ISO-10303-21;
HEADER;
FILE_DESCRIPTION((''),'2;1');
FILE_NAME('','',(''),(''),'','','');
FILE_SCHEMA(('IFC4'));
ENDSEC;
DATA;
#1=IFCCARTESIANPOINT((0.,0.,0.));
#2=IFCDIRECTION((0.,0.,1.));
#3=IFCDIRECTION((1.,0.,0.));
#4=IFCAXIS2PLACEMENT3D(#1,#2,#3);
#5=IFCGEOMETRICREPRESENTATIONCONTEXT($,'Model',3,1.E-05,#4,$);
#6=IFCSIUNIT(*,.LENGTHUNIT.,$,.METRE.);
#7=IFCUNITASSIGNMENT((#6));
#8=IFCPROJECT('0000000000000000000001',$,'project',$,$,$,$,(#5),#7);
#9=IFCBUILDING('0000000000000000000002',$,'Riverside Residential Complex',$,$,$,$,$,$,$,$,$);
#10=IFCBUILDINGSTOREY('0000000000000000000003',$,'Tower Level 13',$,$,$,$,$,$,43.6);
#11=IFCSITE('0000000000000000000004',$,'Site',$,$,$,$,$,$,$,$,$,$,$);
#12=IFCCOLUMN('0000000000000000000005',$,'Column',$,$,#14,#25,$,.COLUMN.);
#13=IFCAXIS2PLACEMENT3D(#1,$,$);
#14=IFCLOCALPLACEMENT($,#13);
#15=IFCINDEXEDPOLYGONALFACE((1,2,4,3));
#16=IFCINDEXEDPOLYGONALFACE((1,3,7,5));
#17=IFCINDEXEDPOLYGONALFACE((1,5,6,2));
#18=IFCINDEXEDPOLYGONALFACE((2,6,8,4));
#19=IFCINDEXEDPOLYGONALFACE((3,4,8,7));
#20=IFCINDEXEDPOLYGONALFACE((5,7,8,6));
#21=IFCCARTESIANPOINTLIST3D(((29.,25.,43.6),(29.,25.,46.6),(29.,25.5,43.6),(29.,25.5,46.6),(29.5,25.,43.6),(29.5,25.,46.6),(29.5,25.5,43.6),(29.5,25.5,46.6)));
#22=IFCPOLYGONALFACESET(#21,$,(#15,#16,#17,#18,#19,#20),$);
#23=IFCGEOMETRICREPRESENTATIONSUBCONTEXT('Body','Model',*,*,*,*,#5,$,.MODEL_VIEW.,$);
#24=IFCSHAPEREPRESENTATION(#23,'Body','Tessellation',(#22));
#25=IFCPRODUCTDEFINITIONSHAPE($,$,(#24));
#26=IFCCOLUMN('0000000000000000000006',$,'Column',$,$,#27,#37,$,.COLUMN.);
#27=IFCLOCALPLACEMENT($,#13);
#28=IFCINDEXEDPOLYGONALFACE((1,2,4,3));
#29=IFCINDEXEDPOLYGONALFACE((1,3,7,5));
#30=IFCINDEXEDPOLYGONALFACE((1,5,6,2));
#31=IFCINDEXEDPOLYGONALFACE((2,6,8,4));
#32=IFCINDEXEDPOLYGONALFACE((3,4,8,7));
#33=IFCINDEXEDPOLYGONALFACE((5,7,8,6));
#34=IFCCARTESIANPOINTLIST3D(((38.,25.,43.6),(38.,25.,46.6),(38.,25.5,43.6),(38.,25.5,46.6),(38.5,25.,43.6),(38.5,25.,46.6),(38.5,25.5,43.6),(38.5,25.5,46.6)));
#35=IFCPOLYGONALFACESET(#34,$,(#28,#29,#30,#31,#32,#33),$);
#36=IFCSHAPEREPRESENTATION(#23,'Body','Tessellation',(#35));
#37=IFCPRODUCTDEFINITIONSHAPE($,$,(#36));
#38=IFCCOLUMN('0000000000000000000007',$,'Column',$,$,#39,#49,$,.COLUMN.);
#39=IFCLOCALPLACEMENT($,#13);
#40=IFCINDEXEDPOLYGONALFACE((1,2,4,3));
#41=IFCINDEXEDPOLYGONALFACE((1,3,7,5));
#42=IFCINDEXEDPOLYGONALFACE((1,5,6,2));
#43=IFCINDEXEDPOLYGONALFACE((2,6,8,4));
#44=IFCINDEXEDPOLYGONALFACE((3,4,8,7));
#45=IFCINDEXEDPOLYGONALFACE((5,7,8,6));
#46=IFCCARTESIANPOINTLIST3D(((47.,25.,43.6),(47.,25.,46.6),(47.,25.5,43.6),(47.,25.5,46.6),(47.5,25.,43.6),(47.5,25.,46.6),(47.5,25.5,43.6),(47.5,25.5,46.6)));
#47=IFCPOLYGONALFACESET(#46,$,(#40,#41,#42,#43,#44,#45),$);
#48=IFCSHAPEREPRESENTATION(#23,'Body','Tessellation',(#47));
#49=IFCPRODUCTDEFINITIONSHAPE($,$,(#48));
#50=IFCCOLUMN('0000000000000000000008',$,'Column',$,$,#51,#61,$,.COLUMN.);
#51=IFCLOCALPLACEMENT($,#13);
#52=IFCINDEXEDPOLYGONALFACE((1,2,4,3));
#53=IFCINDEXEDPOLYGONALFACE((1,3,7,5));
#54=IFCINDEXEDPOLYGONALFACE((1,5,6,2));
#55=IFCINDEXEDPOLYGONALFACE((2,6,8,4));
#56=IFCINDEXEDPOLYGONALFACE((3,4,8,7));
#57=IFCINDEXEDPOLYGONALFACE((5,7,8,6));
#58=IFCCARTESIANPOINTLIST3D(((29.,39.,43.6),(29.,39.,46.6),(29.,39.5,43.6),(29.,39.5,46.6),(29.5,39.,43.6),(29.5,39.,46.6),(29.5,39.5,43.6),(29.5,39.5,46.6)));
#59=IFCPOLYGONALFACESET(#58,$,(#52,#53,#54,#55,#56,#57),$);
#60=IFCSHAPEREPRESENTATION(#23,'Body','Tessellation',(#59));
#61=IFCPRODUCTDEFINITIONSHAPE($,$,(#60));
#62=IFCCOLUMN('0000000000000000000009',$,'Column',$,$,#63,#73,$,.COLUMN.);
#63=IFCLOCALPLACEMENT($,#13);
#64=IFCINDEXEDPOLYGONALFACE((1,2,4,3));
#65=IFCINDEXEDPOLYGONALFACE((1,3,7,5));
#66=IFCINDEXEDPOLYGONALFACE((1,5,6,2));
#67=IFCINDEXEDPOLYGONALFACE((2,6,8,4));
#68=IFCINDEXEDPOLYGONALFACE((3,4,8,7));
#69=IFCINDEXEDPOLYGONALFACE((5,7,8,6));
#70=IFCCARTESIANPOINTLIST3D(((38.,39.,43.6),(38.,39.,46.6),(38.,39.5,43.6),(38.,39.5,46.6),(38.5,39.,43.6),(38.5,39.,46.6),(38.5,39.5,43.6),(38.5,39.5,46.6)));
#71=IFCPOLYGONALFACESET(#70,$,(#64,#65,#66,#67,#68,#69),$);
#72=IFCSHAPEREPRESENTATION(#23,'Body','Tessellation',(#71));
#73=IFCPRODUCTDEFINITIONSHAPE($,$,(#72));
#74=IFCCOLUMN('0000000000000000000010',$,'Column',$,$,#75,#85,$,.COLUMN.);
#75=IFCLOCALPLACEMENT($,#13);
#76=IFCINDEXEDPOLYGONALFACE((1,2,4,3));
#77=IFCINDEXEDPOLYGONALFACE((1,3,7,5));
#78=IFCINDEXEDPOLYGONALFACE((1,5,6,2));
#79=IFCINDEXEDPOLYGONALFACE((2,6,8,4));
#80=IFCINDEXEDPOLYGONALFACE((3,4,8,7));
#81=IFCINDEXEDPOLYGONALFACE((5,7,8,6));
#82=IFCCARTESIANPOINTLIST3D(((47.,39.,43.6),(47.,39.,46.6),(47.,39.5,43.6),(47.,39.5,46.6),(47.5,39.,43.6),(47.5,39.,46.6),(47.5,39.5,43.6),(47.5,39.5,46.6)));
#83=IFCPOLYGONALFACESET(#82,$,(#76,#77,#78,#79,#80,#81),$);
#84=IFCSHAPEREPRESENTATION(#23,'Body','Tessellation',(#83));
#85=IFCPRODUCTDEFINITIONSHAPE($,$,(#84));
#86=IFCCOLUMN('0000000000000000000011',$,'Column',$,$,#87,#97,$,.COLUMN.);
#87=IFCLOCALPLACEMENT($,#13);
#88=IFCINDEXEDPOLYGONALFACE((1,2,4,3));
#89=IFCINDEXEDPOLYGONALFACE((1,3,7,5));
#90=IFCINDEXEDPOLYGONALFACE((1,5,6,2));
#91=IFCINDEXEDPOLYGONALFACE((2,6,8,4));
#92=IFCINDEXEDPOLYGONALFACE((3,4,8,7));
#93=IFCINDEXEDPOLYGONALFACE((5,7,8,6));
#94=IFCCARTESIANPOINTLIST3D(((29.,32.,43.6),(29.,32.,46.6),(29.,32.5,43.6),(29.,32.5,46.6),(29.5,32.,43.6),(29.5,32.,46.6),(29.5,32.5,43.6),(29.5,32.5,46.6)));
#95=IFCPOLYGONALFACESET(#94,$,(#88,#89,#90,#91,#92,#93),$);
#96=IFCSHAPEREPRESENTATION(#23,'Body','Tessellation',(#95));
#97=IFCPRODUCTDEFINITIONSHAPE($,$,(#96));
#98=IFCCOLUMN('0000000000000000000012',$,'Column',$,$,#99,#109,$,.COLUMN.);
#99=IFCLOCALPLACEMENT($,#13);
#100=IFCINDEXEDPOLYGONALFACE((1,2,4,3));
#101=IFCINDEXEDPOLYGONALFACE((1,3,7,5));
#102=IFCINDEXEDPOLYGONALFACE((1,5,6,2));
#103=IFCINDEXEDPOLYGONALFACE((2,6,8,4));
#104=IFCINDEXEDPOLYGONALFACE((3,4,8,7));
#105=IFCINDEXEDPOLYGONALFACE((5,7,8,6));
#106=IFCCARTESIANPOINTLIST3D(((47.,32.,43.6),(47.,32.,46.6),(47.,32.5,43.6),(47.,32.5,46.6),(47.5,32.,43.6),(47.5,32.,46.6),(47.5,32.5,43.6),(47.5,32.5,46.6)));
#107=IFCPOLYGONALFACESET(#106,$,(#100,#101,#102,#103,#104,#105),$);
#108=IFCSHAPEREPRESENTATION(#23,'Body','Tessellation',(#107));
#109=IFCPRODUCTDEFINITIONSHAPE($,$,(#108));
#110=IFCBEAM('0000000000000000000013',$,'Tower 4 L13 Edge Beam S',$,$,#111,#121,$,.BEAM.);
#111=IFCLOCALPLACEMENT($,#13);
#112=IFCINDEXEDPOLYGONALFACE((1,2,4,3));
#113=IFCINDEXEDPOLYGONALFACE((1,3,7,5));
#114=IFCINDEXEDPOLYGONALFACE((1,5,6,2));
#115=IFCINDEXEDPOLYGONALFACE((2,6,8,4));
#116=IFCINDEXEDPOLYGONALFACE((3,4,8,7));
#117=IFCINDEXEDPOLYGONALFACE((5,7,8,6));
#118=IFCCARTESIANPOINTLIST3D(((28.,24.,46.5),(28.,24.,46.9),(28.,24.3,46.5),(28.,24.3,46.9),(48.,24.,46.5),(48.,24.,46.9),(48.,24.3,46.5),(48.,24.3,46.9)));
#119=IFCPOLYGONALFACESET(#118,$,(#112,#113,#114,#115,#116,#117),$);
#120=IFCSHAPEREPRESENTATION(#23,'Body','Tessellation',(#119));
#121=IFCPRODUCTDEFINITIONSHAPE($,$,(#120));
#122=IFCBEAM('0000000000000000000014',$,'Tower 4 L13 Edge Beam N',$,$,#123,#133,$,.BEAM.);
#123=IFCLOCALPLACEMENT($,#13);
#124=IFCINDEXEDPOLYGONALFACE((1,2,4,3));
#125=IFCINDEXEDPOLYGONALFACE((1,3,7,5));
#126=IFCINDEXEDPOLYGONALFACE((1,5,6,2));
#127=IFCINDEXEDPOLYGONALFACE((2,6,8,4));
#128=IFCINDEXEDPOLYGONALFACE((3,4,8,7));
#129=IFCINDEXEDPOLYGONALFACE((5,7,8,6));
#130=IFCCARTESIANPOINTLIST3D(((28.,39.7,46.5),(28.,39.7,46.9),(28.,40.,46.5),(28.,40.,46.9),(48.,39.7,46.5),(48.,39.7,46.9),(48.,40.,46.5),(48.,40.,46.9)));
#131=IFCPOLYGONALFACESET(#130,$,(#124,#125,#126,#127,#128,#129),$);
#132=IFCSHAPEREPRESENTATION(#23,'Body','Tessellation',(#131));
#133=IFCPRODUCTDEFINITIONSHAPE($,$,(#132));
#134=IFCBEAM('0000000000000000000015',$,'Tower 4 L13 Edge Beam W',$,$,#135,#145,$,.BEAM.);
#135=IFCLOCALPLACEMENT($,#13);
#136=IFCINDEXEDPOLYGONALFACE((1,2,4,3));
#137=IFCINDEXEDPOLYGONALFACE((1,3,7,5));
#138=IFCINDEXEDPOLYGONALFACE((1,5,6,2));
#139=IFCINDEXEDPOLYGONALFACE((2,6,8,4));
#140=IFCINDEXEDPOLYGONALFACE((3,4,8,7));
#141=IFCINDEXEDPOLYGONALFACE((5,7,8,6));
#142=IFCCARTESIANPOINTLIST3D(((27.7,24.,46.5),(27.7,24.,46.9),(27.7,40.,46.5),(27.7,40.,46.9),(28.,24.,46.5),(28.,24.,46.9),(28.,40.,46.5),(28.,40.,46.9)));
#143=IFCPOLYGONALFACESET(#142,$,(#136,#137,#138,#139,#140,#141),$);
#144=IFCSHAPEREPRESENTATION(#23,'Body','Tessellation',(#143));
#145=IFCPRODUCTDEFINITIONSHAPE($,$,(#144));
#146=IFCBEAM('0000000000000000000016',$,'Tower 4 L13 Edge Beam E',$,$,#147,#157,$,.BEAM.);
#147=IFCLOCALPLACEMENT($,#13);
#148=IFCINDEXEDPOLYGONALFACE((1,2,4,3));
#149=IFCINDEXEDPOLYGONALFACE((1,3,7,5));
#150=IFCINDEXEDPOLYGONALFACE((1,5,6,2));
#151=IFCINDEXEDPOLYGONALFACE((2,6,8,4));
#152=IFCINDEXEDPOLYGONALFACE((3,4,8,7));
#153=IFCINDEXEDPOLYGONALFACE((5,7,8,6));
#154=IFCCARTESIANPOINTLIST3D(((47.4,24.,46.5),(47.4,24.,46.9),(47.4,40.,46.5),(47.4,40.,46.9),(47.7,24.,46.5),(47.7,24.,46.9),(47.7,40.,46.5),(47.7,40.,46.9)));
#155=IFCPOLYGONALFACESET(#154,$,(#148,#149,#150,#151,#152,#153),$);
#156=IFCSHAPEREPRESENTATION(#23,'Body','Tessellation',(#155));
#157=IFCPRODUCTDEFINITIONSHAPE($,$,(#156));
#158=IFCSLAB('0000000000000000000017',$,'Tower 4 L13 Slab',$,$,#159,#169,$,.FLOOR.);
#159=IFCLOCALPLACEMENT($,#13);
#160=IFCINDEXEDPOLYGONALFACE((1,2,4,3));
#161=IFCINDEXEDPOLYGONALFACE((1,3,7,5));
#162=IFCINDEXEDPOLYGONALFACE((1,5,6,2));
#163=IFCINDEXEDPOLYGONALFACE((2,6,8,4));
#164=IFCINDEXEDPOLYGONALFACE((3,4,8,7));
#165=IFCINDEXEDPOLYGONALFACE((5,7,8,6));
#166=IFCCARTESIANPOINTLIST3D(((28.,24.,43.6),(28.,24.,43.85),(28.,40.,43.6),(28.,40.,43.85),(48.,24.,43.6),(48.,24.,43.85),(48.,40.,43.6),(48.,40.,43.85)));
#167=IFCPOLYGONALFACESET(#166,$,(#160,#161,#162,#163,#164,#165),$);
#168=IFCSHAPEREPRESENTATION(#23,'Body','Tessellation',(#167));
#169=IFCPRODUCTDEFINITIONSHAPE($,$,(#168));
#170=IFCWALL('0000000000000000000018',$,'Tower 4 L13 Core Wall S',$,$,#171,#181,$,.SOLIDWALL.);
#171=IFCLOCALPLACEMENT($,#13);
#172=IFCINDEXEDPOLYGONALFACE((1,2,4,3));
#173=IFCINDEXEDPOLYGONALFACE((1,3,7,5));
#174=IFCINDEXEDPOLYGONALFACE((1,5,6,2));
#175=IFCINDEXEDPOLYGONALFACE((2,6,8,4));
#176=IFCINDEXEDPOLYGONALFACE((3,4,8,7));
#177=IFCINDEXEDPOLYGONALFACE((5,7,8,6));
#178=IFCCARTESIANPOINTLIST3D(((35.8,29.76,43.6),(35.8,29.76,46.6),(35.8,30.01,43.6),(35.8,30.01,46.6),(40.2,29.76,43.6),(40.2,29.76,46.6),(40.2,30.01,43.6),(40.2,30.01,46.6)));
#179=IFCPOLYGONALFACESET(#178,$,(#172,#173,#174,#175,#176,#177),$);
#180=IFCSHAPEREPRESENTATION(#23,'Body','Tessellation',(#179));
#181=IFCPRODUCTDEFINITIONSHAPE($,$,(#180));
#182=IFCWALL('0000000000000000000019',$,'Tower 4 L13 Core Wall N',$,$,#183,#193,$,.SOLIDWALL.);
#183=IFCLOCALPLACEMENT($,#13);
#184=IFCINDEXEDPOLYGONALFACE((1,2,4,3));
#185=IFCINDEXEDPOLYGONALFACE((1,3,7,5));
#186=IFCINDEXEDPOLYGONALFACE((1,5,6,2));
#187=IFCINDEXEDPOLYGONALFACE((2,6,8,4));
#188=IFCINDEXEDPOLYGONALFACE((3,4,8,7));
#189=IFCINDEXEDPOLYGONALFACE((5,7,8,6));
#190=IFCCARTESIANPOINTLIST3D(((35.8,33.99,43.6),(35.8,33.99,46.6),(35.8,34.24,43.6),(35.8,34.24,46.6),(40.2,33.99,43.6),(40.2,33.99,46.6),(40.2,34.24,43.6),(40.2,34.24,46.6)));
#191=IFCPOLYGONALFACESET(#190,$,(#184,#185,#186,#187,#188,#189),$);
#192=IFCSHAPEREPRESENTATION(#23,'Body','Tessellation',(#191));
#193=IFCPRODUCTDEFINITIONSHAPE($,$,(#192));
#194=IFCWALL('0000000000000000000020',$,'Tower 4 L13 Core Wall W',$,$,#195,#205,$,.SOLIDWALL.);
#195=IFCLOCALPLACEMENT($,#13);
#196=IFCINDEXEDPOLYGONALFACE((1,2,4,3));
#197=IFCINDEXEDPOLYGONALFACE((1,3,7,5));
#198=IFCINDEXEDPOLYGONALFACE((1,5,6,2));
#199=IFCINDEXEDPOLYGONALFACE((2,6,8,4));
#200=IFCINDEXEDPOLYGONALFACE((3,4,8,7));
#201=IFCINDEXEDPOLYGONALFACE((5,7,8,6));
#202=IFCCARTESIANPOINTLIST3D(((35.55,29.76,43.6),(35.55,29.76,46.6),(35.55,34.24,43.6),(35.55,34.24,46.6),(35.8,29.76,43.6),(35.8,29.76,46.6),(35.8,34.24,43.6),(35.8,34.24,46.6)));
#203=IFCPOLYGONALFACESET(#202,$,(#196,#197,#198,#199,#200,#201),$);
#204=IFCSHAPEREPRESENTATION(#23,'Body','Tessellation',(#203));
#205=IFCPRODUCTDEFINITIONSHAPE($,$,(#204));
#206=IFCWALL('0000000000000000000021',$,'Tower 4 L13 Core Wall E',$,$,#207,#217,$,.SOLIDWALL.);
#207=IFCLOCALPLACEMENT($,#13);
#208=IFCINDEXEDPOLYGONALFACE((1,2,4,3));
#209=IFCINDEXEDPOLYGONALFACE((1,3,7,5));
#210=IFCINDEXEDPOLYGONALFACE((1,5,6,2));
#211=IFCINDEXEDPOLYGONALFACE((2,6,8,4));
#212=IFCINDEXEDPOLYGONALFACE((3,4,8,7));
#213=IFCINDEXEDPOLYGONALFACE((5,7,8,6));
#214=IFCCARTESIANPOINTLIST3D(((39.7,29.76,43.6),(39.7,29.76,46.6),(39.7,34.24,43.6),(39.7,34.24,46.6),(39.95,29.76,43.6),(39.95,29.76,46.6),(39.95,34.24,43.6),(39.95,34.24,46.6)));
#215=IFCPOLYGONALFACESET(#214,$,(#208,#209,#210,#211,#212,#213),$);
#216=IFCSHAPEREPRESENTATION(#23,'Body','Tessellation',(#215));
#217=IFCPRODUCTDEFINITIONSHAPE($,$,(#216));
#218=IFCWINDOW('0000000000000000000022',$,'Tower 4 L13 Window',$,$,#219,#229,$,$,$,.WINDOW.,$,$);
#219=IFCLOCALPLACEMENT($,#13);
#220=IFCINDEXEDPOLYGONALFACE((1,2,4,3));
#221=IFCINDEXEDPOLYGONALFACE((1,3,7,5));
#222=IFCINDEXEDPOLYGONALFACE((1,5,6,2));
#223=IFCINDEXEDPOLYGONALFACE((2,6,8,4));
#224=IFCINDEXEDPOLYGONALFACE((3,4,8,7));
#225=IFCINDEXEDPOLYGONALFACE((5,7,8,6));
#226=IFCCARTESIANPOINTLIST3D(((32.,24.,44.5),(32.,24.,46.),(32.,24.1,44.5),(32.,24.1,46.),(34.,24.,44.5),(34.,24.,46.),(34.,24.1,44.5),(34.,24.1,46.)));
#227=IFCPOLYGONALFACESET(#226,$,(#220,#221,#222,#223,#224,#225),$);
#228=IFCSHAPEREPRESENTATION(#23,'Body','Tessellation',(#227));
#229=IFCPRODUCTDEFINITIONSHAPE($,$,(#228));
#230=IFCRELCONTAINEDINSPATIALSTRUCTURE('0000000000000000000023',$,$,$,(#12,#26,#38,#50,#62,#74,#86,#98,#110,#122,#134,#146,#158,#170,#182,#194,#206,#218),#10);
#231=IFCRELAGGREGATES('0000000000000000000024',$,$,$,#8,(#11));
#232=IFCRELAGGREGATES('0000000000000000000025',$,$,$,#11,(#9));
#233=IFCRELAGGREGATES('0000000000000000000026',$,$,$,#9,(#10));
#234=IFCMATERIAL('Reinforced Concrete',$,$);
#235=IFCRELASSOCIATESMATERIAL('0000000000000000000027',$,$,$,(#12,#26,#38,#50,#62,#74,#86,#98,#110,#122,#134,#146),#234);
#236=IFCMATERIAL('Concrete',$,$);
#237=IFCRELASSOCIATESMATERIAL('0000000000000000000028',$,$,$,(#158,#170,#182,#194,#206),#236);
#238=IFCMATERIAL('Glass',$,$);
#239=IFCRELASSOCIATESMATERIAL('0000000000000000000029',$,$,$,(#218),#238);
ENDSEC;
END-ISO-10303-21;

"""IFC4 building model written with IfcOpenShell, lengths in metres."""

from ifc_helpers import new_model, si_unit, frame, origin_with_axes, place, context, subcontext, project, spatial, line, indexed_curve, outline, extrude, material, element, save


model = new_model("IFC4")

# Units and contexts
model_context = context("Model", 3, precision=1e-05, world=origin_with_axes())
body_context = subcontext(model_context, "Body", "Model", "MODEL_VIEW")
ifc_project = project(units=[si_unit("LENGTHUNIT", "METRE")], contexts=[model_context])

# Site, building, storey
site = spatial("IfcSite", under=ifc_project, Name="Site")
building = spatial("IfcBuilding", under=site, Name="Riverside Residential Complex")
storey = spatial("IfcBuildingStorey", under=building, Name="Tower Level 13", Elevation=43.6)

# Columns
ifc_material_1 = material(Name="Reinforced Concrete")
for number, where, z_axis, x_axis, name in (
    (1, (29.0, 25.0, 43.6), (0.0, 0.0, 1.0), (1.0, 0.0, 0.0), "Column"),
    (2, (38.0, 25.0, 43.6), (0.0, 0.0, 1.0), (1.0, 0.0, 0.0), "Column"),
    (3, (47.0, 25.0, 43.6), (0.0, 0.0, 1.0), (1.0, 0.0, 0.0), "Column"),
    (4, (29.0, 39.0, 43.6), (0.0, 0.0, 1.0), (1.0, 0.0, 0.0), "Column"),
    (5, (38.0, 39.0, 43.6), (0.0, 0.0, 1.0), (1.0, 0.0, 0.0), "Column"),
    (6, (47.0, 39.0, 43.6), (0.0, 0.0, 1.0), (1.0, 0.0, 0.0), "Column"),
    (7, (29.0, 32.0, 43.6), (0.0, 0.0, 1.0), (1.0, 0.0, 0.0), "Column"),
    (8, (47.0, 32.0, 43.6), (0.0, 0.0, 1.0), (1.0, 0.0, 0.0), "Column"),
):
    element("IfcColumn", number, at=place(None, frame(where, z_axis=z_axis, x_axis=x_axis)), inside=storey, material=ifc_material_1, Name=name, PredefinedType="COLUMN", context=body_context, shape_type="SweptSolid", body=[
        extrude(outline(indexed_curve([(0.0, 0.0), (0.5, 0.0), (0.5, 0.5), (0.0, 0.5)], segments=[line(1, 2, 3, 4, 1)])), origin_with_axes(), (0.0, 0.0, 1.0), 3.0),
    ])

# Beams
for number, where, z_axis, x_axis, name in (
    (9, (28.0, 24.0, 46.5), (0.0, 0.0, 1.0), (1.0, 0.0, 0.0), "Tower 4 L13 Edge Beam S"),
    (10, (28.0, 39.7, 46.5), (0.0, 0.0, 1.0), (1.0, 0.0, 0.0), "Tower 4 L13 Edge Beam N"),
):
    element("IfcBeam", number, at=place(None, frame(where, z_axis=z_axis, x_axis=x_axis)), inside=storey, material=ifc_material_1, Name=name, PredefinedType="BEAM", context=body_context, shape_type="SweptSolid", body=[
        extrude(outline(indexed_curve([(0.0, 0.0), (20.0, 0.0), (20.0, 0.3), (0.0, 0.3)], segments=[line(1, 2, 3, 4, 1)])), origin_with_axes(), (0.0, 0.0, 1.0), 0.4),
    ])
for number, where, z_axis, x_axis, name in (
    (11, (28.0, 24.0, 46.5), (0.0, 0.0, 1.0), (0.0, 1.0, 0.0), "Tower 4 L13 Edge Beam W"),
    (12, (47.7, 24.0, 46.5), (0.0, 0.0, 1.0), (0.0, 1.0, 0.0), "Tower 4 L13 Edge Beam E"),
):
    element("IfcBeam", number, at=place(None, frame(where, z_axis=z_axis, x_axis=x_axis)), inside=storey, material=ifc_material_1, Name=name, PredefinedType="BEAM", context=body_context, shape_type="SweptSolid", body=[
        extrude(outline(indexed_curve([(0.0, 0.0), (16.0, 0.0), (16.0, 0.3), (0.0, 0.3)], segments=[line(1, 2, 3, 4, 1)])), origin_with_axes(), (0.0, 0.0, 1.0), 0.4),
    ])

# Slab
ifc_material_2 = material(Name="Concrete")
slab_placement = place(None, frame((28.0, 24.0, 43.6), z_axis=(0.0, 0.0, 1.0), x_axis=(1.0, 0.0, 0.0)))
element("IfcSlab", 13, at=slab_placement, inside=storey, material=ifc_material_2, Name="Tower 4 L13 Slab", PredefinedType="FLOOR", context=body_context, shape_type="SweptSolid", body=[
    extrude(outline(indexed_curve([(0.0, 0.0), (20.0, 0.0), (20.0, 16.0), (0.0, 16.0)], segments=[line(1, 2, 3, 4, 1)])), origin_with_axes(), (0.0, 0.0, 1.0), 0.25),
])

# Walls
for number, where, z_axis, x_axis, name in (
    (14, (35.8, 29.76, 43.6), (0.0, 0.0, 1.0), (1.0, 0.0, 0.0), "Tower 4 L13 Core Wall S"),
    (15, (35.8, 33.99, 43.6), (0.0, 0.0, 1.0), (1.0, 0.0, 0.0), "Tower 4 L13 Core Wall N"),
):
    element("IfcWall", number, at=place(None, frame(where, z_axis=z_axis, x_axis=x_axis)), inside=storey, material=ifc_material_2, Name=name, PredefinedType="SOLIDWALL", context=body_context, shape_type="SweptSolid", body=[
        extrude(outline(indexed_curve([(0.0, 0.0), (4.4, 0.0), (4.4, 0.25), (0.0, 0.25)], segments=[line(1, 2, 3, 4, 1)])), origin_with_axes(), (0.0, 0.0, 1.0), 3.0),
    ])
for number, where, z_axis, x_axis, name in (
    (16, (35.8, 29.76, 43.6), (0.0, 0.0, 1.0), (0.0, 1.0, 0.0), "Tower 4 L13 Core Wall W"),
    (17, (39.95, 29.76, 43.6), (0.0, 0.0, 1.0), (0.0, 1.0, 0.0), "Tower 4 L13 Core Wall E"),
):
    element("IfcWall", number, at=place(None, frame(where, z_axis=z_axis, x_axis=x_axis)), inside=storey, material=ifc_material_2, Name=name, PredefinedType="SOLIDWALL", context=body_context, shape_type="SweptSolid", body=[
        extrude(outline(indexed_curve([(0.0, 0.0), (4.48, 0.0), (4.48, 0.25), (0.0, 0.25)], segments=[line(1, 2, 3, 4, 1)])), origin_with_axes(), (0.0, 0.0, 1.0), 3.0),
    ])

# Window
ifc_material_3 = material(Name="Glass")
for number, where, z_axis, x_axis, name in (
    (18, (32.0, 24.0, 44.5), (0.0, 0.0, 1.0), (1.0, 0.0, 0.0), "Tower 4 L13 Window"),
):
    element("IfcWindow", number, at=place(None, frame(where, z_axis=z_axis, x_axis=x_axis)), inside=storey, material=ifc_material_3, Name=name, PredefinedType="WINDOW", context=body_context, shape_type="SweptSolid", body=[
        extrude(outline(indexed_curve([(0.0, 0.0), (2.0, 0.0), (2.0, 0.1), (0.0, 0.1)], segments=[line(1, 2, 3, 4, 1)])), origin_with_axes(), (0.0, 0.0, 1.0), 1.5),
    ])

save(model, "model.ifc")
